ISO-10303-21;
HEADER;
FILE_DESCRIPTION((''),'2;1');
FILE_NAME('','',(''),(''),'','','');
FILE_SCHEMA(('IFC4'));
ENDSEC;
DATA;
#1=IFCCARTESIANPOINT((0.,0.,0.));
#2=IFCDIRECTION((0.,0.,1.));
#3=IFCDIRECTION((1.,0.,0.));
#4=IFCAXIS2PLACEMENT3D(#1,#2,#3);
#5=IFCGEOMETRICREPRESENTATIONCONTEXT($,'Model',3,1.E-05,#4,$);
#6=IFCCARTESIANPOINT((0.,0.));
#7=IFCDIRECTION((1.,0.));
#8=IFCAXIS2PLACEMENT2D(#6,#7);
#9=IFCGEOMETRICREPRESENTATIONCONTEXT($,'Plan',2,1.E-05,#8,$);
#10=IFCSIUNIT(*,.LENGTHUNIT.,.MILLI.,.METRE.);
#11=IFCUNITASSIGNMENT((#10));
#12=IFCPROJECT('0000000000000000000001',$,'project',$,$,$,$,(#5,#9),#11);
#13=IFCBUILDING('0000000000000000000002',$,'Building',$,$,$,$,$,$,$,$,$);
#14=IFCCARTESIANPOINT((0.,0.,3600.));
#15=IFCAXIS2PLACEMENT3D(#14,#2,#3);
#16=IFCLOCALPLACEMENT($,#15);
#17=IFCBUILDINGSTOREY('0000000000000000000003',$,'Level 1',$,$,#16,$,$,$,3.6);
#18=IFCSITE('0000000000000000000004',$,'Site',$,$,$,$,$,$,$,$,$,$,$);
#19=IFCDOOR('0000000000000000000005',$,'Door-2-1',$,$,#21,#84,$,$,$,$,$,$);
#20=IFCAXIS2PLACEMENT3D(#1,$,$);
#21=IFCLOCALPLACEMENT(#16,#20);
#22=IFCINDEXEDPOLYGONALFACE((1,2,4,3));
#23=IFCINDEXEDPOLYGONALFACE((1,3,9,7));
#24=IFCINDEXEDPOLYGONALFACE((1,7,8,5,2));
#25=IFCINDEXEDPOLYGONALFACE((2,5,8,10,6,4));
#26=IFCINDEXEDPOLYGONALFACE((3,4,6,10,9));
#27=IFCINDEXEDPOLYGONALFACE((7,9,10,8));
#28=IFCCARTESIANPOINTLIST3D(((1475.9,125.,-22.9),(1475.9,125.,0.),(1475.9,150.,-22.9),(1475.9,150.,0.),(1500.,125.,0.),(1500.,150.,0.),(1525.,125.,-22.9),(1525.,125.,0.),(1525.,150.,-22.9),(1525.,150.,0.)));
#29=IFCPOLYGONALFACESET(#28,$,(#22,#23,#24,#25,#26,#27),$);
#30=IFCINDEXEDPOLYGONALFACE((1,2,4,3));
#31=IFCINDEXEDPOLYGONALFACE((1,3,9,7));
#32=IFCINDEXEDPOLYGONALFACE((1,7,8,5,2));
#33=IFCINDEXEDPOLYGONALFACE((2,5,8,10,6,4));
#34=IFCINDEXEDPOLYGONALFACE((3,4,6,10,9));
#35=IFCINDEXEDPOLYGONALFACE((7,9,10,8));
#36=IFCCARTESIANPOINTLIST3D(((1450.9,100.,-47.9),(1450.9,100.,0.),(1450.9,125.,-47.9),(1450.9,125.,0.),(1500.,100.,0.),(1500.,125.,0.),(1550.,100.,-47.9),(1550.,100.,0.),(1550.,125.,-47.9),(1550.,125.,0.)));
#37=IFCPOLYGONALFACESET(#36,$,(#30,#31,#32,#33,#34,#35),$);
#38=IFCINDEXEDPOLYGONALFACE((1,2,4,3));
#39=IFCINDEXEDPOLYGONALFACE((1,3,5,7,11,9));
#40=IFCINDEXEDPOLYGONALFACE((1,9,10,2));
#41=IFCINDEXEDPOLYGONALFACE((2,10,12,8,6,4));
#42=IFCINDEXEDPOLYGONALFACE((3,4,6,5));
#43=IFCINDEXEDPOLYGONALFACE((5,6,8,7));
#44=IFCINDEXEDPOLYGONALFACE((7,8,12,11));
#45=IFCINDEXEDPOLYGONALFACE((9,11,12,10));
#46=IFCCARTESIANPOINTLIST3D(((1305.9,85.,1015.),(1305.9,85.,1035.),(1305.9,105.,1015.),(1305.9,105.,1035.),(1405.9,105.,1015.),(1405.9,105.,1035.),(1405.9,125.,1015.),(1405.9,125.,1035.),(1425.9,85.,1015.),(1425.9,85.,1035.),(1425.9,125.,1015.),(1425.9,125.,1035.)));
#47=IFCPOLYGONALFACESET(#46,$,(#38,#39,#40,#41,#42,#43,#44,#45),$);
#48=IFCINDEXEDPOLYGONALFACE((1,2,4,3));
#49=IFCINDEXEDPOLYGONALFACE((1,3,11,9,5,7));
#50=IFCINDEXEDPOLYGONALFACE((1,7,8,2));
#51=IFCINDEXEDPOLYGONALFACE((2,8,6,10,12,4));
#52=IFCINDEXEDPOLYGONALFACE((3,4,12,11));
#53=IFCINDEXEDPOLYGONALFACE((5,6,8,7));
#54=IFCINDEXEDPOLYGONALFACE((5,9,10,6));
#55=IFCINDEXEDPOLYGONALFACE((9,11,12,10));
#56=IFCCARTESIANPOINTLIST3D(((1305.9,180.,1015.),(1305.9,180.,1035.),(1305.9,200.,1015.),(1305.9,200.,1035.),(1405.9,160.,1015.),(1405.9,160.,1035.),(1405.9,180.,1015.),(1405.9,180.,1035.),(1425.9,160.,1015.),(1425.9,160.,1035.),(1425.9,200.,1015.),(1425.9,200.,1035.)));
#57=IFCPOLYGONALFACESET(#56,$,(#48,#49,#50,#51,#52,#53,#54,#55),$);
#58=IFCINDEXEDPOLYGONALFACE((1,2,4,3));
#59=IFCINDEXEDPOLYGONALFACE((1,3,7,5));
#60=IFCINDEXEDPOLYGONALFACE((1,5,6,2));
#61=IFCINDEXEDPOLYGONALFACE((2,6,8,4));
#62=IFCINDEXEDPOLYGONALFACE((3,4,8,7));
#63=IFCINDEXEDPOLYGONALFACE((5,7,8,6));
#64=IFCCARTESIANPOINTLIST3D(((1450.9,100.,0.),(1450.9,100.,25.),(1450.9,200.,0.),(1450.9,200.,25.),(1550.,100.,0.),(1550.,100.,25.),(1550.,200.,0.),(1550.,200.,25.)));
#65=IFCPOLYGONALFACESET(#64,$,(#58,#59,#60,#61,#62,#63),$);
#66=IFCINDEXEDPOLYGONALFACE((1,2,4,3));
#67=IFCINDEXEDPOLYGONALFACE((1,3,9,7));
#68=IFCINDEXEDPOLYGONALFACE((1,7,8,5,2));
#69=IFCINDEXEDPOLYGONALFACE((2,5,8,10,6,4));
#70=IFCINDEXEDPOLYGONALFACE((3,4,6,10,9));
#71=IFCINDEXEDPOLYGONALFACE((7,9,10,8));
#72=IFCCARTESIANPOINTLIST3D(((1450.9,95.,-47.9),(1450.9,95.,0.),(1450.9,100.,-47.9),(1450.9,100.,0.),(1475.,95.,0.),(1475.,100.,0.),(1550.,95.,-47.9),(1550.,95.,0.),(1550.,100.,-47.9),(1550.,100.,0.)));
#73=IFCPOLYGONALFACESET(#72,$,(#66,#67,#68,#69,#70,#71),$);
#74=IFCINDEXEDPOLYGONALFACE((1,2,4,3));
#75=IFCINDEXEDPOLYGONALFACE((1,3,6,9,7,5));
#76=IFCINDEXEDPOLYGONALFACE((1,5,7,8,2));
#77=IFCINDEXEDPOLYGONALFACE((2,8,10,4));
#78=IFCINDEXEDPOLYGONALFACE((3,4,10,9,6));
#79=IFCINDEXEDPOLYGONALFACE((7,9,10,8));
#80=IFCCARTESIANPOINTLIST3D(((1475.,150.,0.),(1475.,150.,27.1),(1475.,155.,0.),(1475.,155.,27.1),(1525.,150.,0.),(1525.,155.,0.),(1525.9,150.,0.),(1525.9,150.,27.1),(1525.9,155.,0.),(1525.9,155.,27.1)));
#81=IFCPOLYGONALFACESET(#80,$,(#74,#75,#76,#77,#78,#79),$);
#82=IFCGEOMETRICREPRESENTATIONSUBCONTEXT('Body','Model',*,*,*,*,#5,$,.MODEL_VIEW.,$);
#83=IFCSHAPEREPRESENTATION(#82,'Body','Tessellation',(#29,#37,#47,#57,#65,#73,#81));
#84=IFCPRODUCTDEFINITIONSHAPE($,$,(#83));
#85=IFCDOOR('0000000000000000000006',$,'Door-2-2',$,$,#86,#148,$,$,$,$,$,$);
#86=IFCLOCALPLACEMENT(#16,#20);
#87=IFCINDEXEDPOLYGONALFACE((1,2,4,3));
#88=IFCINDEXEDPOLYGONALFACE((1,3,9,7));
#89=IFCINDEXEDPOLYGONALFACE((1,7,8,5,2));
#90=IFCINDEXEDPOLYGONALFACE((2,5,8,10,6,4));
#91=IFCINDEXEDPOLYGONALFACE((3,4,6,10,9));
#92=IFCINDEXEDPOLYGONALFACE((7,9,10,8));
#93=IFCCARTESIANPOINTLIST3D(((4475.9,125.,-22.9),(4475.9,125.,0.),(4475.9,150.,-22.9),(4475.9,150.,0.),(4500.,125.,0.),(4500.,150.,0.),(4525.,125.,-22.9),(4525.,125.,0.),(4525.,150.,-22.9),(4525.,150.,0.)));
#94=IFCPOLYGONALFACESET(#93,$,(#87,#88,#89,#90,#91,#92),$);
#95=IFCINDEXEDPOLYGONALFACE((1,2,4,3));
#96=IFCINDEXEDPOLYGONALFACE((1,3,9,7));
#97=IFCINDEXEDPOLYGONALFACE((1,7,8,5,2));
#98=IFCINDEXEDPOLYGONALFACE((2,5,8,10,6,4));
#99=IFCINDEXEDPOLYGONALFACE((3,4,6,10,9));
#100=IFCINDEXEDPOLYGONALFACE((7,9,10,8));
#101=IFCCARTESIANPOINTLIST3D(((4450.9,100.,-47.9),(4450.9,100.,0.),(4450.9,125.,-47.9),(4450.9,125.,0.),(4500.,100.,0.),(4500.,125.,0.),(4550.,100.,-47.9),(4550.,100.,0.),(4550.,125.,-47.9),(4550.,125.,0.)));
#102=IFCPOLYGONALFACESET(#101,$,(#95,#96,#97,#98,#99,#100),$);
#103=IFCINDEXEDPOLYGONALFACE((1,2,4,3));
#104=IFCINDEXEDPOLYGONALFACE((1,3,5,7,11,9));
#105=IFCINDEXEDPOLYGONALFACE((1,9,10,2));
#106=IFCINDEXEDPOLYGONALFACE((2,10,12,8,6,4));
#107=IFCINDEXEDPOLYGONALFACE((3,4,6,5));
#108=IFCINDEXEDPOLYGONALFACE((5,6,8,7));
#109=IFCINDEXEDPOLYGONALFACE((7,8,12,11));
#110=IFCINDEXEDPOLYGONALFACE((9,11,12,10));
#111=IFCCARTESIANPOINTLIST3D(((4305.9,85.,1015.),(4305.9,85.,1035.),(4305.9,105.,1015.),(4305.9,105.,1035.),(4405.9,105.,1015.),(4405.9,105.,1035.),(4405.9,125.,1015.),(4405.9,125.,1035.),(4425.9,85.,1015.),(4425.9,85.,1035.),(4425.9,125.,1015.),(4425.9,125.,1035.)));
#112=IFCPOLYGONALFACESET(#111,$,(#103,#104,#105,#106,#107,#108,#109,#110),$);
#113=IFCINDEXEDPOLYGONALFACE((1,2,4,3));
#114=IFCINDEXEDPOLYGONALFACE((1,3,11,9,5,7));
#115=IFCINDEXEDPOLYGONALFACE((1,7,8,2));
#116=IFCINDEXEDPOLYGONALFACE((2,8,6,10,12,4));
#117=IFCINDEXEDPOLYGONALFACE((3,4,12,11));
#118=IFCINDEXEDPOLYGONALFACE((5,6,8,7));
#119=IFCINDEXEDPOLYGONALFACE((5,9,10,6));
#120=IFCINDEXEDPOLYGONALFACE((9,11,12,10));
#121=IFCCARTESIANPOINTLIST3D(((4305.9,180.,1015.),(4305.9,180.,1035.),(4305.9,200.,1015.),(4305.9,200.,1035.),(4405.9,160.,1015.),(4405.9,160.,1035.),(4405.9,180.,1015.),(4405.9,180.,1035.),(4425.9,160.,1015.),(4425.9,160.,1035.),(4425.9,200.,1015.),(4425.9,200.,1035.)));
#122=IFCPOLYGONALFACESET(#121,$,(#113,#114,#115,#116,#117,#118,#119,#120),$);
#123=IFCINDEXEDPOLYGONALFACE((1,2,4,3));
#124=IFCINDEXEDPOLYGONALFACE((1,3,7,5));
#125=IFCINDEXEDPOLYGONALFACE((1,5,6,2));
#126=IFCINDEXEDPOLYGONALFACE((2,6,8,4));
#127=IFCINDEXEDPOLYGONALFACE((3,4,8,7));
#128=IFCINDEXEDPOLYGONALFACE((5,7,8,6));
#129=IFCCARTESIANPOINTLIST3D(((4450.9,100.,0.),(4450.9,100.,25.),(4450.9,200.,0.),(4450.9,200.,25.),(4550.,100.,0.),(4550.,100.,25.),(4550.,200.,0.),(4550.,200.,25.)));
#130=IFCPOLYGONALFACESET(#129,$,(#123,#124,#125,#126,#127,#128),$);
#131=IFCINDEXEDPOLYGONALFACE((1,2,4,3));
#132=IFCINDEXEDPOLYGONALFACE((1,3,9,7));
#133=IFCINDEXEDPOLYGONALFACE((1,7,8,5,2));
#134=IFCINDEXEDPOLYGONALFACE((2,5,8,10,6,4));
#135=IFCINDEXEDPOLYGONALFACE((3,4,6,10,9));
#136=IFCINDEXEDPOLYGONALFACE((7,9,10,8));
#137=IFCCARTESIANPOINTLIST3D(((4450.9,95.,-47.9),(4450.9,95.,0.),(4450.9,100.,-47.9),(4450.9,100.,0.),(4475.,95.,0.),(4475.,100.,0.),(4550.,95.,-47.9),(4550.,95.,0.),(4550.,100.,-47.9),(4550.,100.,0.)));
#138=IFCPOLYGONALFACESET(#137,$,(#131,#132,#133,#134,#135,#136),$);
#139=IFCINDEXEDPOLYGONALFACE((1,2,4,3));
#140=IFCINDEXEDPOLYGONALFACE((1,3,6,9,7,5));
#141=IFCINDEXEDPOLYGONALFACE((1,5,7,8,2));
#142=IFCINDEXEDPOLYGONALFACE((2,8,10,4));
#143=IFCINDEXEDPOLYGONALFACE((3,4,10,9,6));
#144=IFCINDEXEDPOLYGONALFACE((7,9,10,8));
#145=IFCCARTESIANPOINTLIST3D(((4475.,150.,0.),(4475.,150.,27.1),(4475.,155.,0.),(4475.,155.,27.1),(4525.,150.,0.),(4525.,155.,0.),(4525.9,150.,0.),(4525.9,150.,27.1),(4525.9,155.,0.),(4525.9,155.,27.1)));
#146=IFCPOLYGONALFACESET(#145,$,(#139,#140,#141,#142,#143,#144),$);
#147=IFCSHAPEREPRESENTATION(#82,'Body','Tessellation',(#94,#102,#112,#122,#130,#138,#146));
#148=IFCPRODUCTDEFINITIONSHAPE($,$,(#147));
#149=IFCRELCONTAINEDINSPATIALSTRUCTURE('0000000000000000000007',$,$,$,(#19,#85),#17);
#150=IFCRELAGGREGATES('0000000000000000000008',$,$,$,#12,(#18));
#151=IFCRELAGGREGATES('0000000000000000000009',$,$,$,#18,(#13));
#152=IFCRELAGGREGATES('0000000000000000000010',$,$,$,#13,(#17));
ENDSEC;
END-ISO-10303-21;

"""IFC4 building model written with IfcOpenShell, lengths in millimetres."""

from ifc_helpers import new_model, si_unit, frame, origin_with_axes, origin_2d_with_axis, place, context, subcontext, project, spatial, line, indexed_curve, outline, extrude, element, save


model = new_model("IFC4")

# Units and contexts
model_context = context("Model", 3, precision=1e-05, world=origin_with_axes())
plan_context = context("Plan", 2, precision=1e-05, world=origin_2d_with_axis())
body_context = subcontext(model_context, "Body", "Model", "MODEL_VIEW")
ifc_project = project(units=[si_unit("LENGTHUNIT", "METRE", prefix="MILLI")], contexts=[model_context, plan_context])

# Site, building, storey
site = spatial("IfcSite", under=ifc_project, Name="Site")
building = spatial("IfcBuilding", under=site, Name="Building")
storey_placement = place(None, frame((0.0, 0.0, 3600.0), z_axis=(0.0, 0.0, 1.0), x_axis=(1.0, 0.0, 0.0)))
storey = spatial("IfcBuildingStorey", under=building, at=storey_placement, Name="Level 1", Elevation=3.6)

# Doors
door_1_placement = place(storey_placement, frame((1500.0, 100.0, 0.0), z_axis=(0.0, 0.0, 1.0), x_axis=(1.0, 0.0, 0.0)))
element("IfcDoor", 1, at=door_1_placement, inside=storey, Name="Door-2-1", context=body_context, shape_type="SweptSolid", body=[
    extrude(outline(indexed_curve([(0.0, 0.0), (0.0, 2.1), (0.9, 2.1), (0.9, 0.0), (-24.1, 0.0), (-24.1, -22.9), (25.0, -22.9), (25.0, 0.0)], segments=[line(1, 2, 3, 4, 5, 6, 7, 8, 1)])), frame((0.0, 25.0, 0.0), z_axis=(0.0, -1.0, 0.0), x_axis=(1.0, 0.0, 0.0)), (0.0, 0.0, -1.0), 25.0),
    extrude(outline(indexed_curve([(0.0, 0.0), (0.0, 2.1), (0.9, 2.1), (0.9, 0.0), (-49.1, 0.0), (-49.1, -47.9), (50.0, -47.9), (50.0, 0.0)], segments=[line(1, 2, 3, 4, 5, 6, 7, 8, 1)])), frame((0.0, 0.0, 0.0), z_axis=(0.0, -1.0, 0.0), x_axis=(1.0, 0.0, 0.0)), (0.0, 0.0, -1.0), 25.0),
    extrude(outline(indexed_curve([(0.0, 0.0), (-49.1, 0.0), (-49.1, 35.0), (0.0, 35.0)], segments=[line(1, 2, 3, 4, 1)])), frame((25.0, 25.0, 25.0), z_axis=(0.0, 0.0, 1.0), x_axis=(1.0, 0.0, 0.0)), (0.0, 0.0, 1.0), -47.9),
    extrude(outline(indexed_curve([(0.0, 0.0), (0.0, -40.0), (-120.0, -40.0), (-120.0, -20.0), (-20.0, -20.0), (-20.0, 0.0)], segments=[line(1, 2, 3, 4, 5, 6, 1)])), frame((-74.1, 25.0, 1015.0), z_axis=(0.0, 0.0, 1.0), x_axis=(1.0, 0.0, 0.0)), (0.0, 0.0, 1.0), 20.0),
    extrude(outline(indexed_curve([(0.0, 0.0), (0.0, 40.0), (-120.0, 40.0), (-120.0, 20.0), (-20.0, 20.0), (-20.0, 0.0)], segments=[line(1, 2, 3, 4, 5, 6, 1)])), frame((-74.1, 60.0, 1015.0), z_axis=(0.0, 0.0, 1.0), x_axis=(1.0, 0.0, 0.0)), (0.0, 0.0, 1.0), 20.0),
    extrude(outline(indexed_curve([(0.0, 0.0), (-99.1, 0.0), (-99.1, 100.0), (0.0, 100.0)], segments=[line(1, 2, 3, 4, 1)])), frame((50.0, 0.0, 0.0), z_axis=(0.0, 0.0, 1.0), x_axis=(1.0, 0.0, 0.0)), (0.0, 0.0, 1.0), 25.0),
    extrude(outline(indexed_curve([(0.0, 0.0), (0.0, 27.1), (50.9, 27.1), (50.9, 0.0), (-24.1, 0.0), (-24.1, -47.9), (75.0, -47.9), (75.0, 0.0)], segments=[line(1, 2, 3, 4, 5, 6, 7, 8, 1)])), frame((-25.0, -5.0, 0.0), z_axis=(0.0, -1.0, 0.0), x_axis=(1.0, 0.0, 0.0)), (0.0, 0.0, -1.0), 5.0),
    extrude(outline(indexed_curve([(0.0, 0.0), (0.0, 27.1), (50.9, 27.1), (50.9, 0.0), (0.9, 0.0), (0.9, -22.9), (50.0, -22.9), (50.0, 0.0)], segments=[line(1, 2, 3, 4, 5, 6, 7, 8, 1)])), frame((-25.0, 50.0, 0.0), z_axis=(0.0, -1.0, 0.0), x_axis=(1.0, 0.0, 0.0)), (0.0, 0.0, -1.0), 5.0),
])
door_2_placement = place(storey_placement, frame((4500.0, 100.0, 0.0), z_axis=(0.0, 0.0, 1.0), x_axis=(1.0, 0.0, 0.0)))
element("IfcDoor", 2, at=door_2_placement, inside=storey, Name="Door-2-2", context=body_context, shape_type="SweptSolid", body=[
    extrude(outline(indexed_curve([(0.0, 0.0), (0.0, 2.1), (0.9, 2.1), (0.9, 0.0), (-24.1, 0.0), (-24.1, -22.9), (25.0, -22.9), (25.0, 0.0)], segments=[line(1, 2, 3, 4, 5, 6, 7, 8, 1)])), frame((0.0, 25.0, 0.0), z_axis=(0.0, -1.0, 0.0), x_axis=(1.0, 0.0, 0.0)), (0.0, 0.0, -1.0), 25.0),
    extrude(outline(indexed_curve([(0.0, 0.0), (0.0, 2.1), (0.9, 2.1), (0.9, 0.0), (-49.1, 0.0), (-49.1, -47.9), (50.0, -47.9), (50.0, 0.0)], segments=[line(1, 2, 3, 4, 5, 6, 7, 8, 1)])), frame((0.0, 0.0, 0.0), z_axis=(0.0, -1.0, 0.0), x_axis=(1.0, 0.0, 0.0)), (0.0, 0.0, -1.0), 25.0),
    extrude(outline(indexed_curve([(0.0, 0.0), (-49.1, 0.0), (-49.1, 35.0), (0.0, 35.0)], segments=[line(1, 2, 3, 4, 1)])), frame((25.0, 25.0, 25.0), z_axis=(0.0, 0.0, 1.0), x_axis=(1.0, 0.0, 0.0)), (0.0, 0.0, 1.0), -47.9),
    extrude(outline(indexed_curve([(0.0, 0.0), (0.0, -40.0), (-120.0, -40.0), (-120.0, -20.0), (-20.0, -20.0), (-20.0, 0.0)], segments=[line(1, 2, 3, 4, 5, 6, 1)])), frame((-74.1, 25.0, 1015.0), z_axis=(0.0, 0.0, 1.0), x_axis=(1.0, 0.0, 0.0)), (0.0, 0.0, 1.0), 20.0),
    extrude(outline(indexed_curve([(0.0, 0.0), (0.0, 40.0), (-120.0, 40.0), (-120.0, 20.0), (-20.0, 20.0), (-20.0, 0.0)], segments=[line(1, 2, 3, 4, 5, 6, 1)])), frame((-74.1, 60.0, 1015.0), z_axis=(0.0, 0.0, 1.0), x_axis=(1.0, 0.0, 0.0)), (0.0, 0.0, 1.0), 20.0),
    extrude(outline(indexed_curve([(0.0, 0.0), (-99.1, 0.0), (-99.1, 100.0), (0.0, 100.0)], segments=[line(1, 2, 3, 4, 1)])), frame((50.0, 0.0, 0.0), z_axis=(0.0, 0.0, 1.0), x_axis=(1.0, 0.0, 0.0)), (0.0, 0.0, 1.0), 25.0),
    extrude(outline(indexed_curve([(0.0, 0.0), (0.0, 27.1), (50.9, 27.1), (50.9, 0.0), (-24.1, 0.0), (-24.1, -47.9), (75.0, -47.9), (75.0, 0.0)], segments=[line(1, 2, 3, 4, 5, 6, 7, 8, 1)])), frame((-25.0, -5.0, 0.0), z_axis=(0.0, -1.0, 0.0), x_axis=(1.0, 0.0, 0.0)), (0.0, 0.0, -1.0), 5.0),
    extrude(outline(indexed_curve([(0.0, 0.0), (0.0, 27.1), (50.9, 27.1), (50.9, 0.0), (0.9, 0.0), (0.9, -22.9), (50.0, -22.9), (50.0, 0.0)], segments=[line(1, 2, 3, 4, 5, 6, 7, 8, 1)])), frame((-25.0, 50.0, 0.0), z_axis=(0.0, -1.0, 0.0), x_axis=(1.0, 0.0, 0.0)), (0.0, 0.0, -1.0), 5.0),
])

save(model, "model.ifc")
